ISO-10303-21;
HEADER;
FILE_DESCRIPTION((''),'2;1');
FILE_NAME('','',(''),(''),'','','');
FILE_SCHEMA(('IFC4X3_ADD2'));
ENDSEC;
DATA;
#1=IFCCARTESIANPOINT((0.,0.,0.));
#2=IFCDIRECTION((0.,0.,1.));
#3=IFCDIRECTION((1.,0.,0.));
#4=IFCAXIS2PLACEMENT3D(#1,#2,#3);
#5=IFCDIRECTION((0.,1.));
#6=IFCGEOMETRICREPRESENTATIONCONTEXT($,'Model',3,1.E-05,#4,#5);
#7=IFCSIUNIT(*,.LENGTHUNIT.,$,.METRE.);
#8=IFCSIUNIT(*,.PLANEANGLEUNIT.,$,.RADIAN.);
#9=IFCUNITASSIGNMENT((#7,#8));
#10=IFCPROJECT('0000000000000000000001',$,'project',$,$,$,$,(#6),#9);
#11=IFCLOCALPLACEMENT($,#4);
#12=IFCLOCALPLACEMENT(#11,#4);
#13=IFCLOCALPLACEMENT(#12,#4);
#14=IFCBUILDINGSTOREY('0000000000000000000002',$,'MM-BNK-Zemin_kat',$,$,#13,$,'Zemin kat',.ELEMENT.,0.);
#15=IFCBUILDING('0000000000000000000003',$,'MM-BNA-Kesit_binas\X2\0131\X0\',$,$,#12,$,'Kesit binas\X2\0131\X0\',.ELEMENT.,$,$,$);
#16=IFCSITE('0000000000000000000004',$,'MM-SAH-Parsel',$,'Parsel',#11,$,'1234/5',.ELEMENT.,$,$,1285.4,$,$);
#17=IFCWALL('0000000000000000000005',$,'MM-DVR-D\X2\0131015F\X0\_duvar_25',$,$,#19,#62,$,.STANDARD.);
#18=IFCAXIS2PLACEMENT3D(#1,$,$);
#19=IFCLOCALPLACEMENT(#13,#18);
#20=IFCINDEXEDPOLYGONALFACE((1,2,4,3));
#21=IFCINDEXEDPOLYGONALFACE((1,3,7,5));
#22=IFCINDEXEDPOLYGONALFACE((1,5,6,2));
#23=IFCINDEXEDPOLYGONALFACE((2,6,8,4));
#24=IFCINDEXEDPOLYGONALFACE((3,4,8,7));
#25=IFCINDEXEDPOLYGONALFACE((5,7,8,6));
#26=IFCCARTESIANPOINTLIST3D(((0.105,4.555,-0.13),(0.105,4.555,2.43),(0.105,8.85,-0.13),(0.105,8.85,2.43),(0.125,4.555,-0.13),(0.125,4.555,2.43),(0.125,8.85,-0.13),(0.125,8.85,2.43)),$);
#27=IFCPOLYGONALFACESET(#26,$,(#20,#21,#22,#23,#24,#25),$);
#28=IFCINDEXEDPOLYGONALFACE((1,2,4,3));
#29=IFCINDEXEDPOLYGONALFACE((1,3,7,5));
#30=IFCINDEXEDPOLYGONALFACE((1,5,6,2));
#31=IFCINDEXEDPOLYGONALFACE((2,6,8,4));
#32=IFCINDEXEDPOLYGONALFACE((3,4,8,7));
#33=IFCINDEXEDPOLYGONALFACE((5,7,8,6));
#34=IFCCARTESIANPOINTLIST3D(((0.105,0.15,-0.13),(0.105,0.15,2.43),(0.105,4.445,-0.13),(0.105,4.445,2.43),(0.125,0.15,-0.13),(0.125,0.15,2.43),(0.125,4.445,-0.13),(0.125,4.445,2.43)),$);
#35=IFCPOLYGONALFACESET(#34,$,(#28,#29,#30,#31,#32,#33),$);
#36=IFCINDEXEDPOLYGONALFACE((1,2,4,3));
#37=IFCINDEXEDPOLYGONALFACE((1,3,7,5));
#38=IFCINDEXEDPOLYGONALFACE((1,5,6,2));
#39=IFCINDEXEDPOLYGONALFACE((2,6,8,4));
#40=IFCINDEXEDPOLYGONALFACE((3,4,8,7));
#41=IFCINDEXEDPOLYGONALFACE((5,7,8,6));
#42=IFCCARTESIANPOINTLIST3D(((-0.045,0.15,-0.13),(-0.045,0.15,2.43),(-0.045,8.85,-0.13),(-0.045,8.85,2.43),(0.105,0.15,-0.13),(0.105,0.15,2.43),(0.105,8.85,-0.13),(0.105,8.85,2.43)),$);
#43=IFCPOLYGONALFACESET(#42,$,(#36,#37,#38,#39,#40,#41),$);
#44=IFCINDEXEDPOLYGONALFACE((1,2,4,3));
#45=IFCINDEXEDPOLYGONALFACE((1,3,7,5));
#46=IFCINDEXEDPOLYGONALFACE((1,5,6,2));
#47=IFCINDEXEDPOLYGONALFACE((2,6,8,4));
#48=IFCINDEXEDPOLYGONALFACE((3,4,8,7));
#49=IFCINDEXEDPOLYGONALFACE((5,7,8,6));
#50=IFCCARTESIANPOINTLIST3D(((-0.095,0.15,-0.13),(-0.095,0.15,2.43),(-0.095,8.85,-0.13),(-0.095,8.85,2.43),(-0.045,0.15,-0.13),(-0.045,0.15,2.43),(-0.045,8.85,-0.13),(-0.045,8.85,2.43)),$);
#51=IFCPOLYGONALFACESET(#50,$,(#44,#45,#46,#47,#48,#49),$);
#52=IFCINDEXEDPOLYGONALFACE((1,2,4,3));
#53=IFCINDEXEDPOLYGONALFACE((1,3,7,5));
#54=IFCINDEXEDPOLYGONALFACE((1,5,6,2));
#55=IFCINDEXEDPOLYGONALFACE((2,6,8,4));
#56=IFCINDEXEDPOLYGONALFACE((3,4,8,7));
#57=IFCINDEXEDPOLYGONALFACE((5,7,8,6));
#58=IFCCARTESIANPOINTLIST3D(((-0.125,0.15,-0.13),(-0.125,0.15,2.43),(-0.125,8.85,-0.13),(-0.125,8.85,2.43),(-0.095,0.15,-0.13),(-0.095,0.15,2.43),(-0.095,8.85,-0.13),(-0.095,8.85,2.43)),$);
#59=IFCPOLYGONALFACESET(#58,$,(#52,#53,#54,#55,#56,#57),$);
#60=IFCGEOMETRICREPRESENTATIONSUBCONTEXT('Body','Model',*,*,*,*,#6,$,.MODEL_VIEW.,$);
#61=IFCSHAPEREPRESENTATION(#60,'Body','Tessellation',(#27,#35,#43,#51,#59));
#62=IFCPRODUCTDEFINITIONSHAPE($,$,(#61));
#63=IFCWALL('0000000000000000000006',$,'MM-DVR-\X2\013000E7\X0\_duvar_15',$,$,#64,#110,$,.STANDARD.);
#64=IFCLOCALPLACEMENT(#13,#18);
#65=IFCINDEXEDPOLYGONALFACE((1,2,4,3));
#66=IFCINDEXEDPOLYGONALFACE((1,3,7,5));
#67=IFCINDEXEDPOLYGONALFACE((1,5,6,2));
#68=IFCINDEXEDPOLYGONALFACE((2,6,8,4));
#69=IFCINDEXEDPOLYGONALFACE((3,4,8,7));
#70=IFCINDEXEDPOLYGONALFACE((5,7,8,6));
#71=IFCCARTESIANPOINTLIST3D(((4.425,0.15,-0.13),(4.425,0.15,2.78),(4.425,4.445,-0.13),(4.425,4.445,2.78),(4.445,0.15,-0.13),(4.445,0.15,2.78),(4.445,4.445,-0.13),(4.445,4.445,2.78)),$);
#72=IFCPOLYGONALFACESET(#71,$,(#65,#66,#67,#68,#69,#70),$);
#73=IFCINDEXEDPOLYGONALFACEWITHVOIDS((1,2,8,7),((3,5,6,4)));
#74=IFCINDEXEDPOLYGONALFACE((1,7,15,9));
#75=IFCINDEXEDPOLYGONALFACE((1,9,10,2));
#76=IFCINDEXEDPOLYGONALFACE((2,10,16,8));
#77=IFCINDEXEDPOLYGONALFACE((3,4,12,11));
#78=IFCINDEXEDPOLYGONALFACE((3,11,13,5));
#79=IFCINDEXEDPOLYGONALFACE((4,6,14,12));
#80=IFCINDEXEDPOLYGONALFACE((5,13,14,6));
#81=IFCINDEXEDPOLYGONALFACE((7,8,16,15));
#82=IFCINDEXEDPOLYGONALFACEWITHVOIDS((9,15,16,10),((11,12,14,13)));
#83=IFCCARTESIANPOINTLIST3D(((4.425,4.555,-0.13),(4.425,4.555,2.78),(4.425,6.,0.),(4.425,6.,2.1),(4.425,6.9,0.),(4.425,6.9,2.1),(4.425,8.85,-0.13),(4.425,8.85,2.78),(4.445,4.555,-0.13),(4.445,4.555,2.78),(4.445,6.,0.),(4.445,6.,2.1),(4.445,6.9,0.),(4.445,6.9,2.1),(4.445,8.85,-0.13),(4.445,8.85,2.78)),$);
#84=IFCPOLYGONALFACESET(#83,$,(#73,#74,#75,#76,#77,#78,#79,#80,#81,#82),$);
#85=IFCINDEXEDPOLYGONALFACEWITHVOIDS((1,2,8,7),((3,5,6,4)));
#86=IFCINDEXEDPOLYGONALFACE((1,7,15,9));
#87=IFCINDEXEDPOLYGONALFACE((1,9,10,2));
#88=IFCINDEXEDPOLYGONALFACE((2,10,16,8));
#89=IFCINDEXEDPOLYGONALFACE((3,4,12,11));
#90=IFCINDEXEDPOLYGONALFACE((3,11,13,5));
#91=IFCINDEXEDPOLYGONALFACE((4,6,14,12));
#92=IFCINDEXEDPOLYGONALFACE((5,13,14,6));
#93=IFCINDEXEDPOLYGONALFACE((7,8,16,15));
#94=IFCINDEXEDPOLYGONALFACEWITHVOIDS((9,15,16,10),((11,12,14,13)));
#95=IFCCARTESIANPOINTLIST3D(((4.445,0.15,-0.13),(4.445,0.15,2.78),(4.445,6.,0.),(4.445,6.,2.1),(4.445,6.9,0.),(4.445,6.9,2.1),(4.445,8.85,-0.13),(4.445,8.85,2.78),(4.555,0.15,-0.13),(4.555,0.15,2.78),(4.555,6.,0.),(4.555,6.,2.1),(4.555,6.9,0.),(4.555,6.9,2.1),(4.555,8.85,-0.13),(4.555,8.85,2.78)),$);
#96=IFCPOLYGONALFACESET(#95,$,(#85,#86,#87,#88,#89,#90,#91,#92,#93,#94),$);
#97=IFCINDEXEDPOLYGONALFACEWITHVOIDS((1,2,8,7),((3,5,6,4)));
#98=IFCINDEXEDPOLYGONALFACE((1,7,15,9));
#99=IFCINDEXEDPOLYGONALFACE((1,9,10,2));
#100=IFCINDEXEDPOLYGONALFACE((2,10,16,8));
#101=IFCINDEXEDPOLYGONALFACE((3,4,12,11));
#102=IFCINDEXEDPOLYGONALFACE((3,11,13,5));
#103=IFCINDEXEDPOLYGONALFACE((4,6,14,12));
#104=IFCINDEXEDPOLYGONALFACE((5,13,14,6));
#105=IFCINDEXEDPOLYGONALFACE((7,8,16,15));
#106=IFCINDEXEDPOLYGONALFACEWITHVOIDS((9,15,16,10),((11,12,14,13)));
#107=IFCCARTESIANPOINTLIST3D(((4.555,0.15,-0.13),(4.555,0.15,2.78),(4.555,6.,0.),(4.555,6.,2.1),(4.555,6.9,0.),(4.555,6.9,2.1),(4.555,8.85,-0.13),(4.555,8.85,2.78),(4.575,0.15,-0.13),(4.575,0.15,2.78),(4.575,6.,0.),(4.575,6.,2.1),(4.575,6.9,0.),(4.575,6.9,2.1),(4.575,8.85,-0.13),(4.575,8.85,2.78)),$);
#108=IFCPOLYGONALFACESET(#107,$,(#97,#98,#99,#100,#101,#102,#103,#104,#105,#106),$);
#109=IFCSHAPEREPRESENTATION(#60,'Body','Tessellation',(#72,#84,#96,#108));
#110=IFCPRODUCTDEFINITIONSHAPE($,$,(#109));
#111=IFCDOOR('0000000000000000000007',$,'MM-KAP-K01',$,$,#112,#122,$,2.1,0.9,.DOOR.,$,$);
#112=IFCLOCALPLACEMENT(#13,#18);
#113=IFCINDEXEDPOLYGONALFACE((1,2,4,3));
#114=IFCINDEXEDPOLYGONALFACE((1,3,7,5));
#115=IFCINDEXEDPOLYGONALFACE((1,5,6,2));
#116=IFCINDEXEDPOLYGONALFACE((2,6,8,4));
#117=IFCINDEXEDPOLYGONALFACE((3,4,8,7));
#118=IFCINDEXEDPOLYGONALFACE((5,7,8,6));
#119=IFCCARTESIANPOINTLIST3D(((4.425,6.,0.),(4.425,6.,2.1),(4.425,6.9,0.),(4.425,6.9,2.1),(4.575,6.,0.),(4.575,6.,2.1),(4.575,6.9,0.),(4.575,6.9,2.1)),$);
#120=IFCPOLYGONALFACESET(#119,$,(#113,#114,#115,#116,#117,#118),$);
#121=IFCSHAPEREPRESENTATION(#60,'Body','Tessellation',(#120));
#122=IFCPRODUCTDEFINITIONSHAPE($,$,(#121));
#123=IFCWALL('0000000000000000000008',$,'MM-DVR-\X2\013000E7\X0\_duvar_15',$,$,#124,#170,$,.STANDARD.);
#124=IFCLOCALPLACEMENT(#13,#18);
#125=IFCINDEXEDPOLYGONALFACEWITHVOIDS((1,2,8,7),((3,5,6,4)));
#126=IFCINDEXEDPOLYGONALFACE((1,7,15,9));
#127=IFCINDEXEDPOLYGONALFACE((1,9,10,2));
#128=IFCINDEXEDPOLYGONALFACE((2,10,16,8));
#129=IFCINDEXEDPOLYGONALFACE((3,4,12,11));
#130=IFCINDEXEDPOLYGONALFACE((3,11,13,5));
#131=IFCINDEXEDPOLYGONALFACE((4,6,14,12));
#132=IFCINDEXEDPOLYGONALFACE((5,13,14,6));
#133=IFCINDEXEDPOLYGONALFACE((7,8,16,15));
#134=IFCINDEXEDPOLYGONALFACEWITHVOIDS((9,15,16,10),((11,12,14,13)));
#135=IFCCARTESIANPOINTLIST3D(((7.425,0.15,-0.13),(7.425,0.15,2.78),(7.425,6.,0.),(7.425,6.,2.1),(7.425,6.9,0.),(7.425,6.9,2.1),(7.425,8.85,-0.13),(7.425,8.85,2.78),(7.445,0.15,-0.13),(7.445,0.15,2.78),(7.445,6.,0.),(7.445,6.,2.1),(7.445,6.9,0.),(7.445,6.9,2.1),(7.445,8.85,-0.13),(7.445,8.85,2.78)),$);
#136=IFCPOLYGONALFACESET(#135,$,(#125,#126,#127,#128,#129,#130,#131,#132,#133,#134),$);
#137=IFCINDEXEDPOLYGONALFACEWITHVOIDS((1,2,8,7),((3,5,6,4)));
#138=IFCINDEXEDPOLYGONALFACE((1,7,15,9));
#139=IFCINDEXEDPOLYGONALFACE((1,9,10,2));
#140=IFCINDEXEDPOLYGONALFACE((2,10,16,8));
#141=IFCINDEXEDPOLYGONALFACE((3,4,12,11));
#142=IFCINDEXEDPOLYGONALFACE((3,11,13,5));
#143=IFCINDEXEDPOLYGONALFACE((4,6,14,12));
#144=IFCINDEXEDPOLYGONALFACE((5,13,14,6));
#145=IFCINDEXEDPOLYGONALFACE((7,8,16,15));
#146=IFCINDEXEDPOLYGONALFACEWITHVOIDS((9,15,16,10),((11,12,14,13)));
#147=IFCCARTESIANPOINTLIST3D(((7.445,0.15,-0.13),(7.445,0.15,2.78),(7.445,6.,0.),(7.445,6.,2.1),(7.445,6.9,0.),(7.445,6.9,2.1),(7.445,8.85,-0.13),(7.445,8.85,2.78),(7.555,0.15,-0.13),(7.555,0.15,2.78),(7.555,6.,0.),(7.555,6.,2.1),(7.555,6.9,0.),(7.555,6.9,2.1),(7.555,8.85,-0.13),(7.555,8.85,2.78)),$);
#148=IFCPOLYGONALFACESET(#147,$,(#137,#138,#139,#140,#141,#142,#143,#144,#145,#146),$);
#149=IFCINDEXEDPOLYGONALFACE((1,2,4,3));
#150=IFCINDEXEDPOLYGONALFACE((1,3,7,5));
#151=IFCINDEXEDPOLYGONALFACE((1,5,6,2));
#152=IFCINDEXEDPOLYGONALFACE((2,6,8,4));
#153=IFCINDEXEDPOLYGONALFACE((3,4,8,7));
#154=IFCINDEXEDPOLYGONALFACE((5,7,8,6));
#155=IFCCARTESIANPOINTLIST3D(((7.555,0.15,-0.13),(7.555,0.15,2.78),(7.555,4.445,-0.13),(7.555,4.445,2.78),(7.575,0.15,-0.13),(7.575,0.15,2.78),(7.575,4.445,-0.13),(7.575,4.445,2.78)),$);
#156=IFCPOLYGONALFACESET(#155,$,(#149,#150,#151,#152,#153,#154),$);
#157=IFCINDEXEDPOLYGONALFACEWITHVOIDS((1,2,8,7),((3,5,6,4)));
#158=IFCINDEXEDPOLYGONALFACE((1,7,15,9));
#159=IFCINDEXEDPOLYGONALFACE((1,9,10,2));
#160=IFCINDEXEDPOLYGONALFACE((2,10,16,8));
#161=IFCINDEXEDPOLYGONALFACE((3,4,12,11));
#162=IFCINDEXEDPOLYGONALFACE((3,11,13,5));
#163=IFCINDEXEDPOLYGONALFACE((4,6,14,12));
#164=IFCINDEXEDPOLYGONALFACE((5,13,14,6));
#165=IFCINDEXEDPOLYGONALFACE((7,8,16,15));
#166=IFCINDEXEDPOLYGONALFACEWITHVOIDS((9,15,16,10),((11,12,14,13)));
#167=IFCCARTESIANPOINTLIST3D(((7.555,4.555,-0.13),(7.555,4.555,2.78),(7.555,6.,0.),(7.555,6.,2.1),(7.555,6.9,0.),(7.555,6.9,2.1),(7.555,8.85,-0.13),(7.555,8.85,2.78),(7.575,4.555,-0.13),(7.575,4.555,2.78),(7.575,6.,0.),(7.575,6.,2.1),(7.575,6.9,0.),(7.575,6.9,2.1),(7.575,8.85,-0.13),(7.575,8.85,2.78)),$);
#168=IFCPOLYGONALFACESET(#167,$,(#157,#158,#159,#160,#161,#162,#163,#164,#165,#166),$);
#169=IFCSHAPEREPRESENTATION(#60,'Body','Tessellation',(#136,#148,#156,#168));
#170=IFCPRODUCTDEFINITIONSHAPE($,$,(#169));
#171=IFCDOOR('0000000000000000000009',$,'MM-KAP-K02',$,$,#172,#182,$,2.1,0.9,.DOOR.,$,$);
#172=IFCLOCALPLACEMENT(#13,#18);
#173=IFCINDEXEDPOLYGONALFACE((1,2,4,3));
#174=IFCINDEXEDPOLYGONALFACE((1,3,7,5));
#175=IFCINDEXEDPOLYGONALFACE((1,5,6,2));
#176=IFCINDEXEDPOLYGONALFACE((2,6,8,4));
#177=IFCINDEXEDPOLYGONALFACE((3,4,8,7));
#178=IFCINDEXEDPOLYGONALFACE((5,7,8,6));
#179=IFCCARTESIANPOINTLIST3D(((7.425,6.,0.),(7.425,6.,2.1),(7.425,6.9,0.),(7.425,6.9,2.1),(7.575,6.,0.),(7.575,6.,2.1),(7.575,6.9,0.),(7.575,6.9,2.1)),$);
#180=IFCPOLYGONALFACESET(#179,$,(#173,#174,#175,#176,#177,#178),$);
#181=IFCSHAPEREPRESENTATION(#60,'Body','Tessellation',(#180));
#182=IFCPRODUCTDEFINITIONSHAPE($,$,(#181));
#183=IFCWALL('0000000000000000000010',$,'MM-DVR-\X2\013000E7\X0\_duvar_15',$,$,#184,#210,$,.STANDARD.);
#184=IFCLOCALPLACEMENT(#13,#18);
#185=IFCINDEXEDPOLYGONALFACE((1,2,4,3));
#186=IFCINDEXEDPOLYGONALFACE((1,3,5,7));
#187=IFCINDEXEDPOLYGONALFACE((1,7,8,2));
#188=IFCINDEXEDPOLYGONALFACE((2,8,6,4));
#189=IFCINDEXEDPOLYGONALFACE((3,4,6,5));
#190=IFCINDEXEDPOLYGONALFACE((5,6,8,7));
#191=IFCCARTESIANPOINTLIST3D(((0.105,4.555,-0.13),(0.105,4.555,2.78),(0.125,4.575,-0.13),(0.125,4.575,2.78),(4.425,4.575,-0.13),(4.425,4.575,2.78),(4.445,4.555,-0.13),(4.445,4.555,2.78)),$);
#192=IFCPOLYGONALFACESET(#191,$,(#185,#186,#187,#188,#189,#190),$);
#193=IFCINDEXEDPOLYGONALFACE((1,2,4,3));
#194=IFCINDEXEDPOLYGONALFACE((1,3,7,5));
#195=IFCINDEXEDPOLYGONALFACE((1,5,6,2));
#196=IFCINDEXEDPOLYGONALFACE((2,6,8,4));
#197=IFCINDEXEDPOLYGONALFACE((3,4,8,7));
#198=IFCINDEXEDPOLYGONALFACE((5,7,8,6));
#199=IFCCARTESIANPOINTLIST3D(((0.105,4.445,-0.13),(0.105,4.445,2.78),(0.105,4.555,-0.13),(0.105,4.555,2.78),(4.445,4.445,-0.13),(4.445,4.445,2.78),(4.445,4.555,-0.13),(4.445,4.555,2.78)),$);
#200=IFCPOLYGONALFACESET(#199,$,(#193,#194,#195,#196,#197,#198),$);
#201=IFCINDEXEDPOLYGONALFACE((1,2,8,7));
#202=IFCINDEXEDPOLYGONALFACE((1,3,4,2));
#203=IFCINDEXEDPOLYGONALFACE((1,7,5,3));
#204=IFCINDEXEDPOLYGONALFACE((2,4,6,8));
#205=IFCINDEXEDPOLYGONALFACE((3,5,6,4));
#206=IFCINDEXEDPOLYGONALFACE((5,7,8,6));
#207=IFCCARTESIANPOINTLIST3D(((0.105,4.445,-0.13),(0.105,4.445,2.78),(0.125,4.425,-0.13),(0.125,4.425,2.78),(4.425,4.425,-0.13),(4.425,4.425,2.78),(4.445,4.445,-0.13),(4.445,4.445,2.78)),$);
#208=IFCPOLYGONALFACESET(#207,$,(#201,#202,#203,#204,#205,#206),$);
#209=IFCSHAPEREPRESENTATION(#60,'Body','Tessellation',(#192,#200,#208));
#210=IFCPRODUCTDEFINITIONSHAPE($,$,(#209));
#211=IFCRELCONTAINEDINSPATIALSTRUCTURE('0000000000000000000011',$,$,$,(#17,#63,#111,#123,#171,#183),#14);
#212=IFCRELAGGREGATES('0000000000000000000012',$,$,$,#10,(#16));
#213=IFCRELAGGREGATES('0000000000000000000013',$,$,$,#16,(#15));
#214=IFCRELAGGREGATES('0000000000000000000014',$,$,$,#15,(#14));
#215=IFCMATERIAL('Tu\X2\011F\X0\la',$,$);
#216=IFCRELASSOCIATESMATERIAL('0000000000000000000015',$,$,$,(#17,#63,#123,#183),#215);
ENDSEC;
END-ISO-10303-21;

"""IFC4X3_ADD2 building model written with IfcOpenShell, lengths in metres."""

from ifc_helpers import new_model, si_unit, direction, frame, origin, origin_with_axes, place, context, subcontext, project, spatial, polyline, outline, extrude, material, element, fill, save


model = new_model("IFC4X3_ADD2")

# Units and contexts
model_context = context("Model", 3, precision=1e-05, world=origin_with_axes(), true_north=direction((0.0, 1.0)))
body_context = subcontext(model_context, "Body", "Model", "MODEL_VIEW")
ifc_project = project(units=[si_unit("LENGTHUNIT", "METRE"), si_unit("PLANEANGLEUNIT", "RADIAN")], contexts=[model_context])

# Site, building, storey
site_placement = place(None, origin_with_axes())
site = spatial("IfcSite", under=ifc_project, at=site_placement, Name="MM-SAH-Parsel", ObjectType="Parsel", LongName="1234/5", CompositionType="ELEMENT", RefElevation=1285.4)
building_placement = place(site_placement, origin_with_axes())
building = spatial("IfcBuilding", under=site, at=building_placement, Name="MM-BNA-Kesit_binası", LongName="Kesit binası", CompositionType="ELEMENT")
storey_placement = place(building_placement, origin_with_axes())
storey = spatial("IfcBuildingStorey", under=building, at=storey_placement, Name="MM-BNK-Zemin_kat", LongName="Zemin kat", CompositionType="ELEMENT", Elevation=0.0)

# Shared definitions
ifc_material_1 = material(Name="Tuğla")

# Wall
wall_1_placement = place(storey_placement, origin_with_axes())
element("IfcWall", 1, at=wall_1_placement, inside=storey, material=ifc_material_1, Name="MM-DVR-Dış_duvar_25", PredefinedType="STANDARD", context=body_context, shape_type="SweptSolid", body=[
    extrude(outline(polyline([(0.105, 8.85), (0.105, 4.555), (0.125, 4.555), (0.125, 8.85), (0.105, 8.85)])), frame((0.0, 0.0, -0.13)), (0.0, 0.0, 1.0), 2.56),
    extrude(outline(polyline([(0.105, 4.445), (0.105, 0.15), (0.125, 0.15), (0.125, 4.445), (0.105, 4.445)])), frame((0.0, 0.0, -0.13)), (0.0, 0.0, 1.0), 2.56),
    extrude(outline(polyline([(-0.045, 8.85), (-0.045, 0.15), (0.105, 0.15), (0.105, 8.85), (-0.045, 8.85)])), frame((0.0, 0.0, -0.13)), (0.0, 0.0, 1.0), 2.56),
    extrude(outline(polyline([(-0.095, 8.85), (-0.095, 0.15), (-0.045, 0.15), (-0.045, 8.85), (-0.095, 8.85)])), frame((0.0, 0.0, -0.13)), (0.0, 0.0, 1.0), 2.56),
    extrude(outline(polyline([(-0.125, 8.85), (-0.125, 0.15), (-0.095, 0.15), (-0.095, 8.85), (-0.125, 8.85)])), frame((0.0, 0.0, -0.13)), (0.0, 0.0, 1.0), 2.56),
])

# Walls, openings, doors
wall_2_placement = place(storey_placement, origin_with_axes())
wall_2 = element("IfcWall", 2, at=wall_2_placement, inside=storey, material=ifc_material_1, Name="MM-DVR-İç_duvar_15", PredefinedType="STANDARD", context=body_context, shape_type="SweptSolid", body=[
    extrude(outline(polyline([(4.445, 0.15), (4.445, 4.445), (4.425, 4.445), (4.425, 0.15), (4.445, 0.15)])), frame((0.0, 0.0, -0.13)), (0.0, 0.0, 1.0), 2.91),
    extrude(outline(polyline([(4.445, 4.555), (4.445, 8.85), (4.425, 8.85), (4.425, 4.555), (4.445, 4.555)])), frame((0.0, 0.0, -0.13)), (0.0, 0.0, 1.0), 2.91),
    extrude(outline(polyline([(4.555, 0.15), (4.555, 8.85), (4.445, 8.85), (4.445, 0.15), (4.555, 0.15)])), frame((0.0, 0.0, -0.13)), (0.0, 0.0, 1.0), 2.91),
    extrude(outline(polyline([(4.575, 0.15), (4.575, 8.85), (4.555, 8.85), (4.555, 0.15), (4.575, 0.15)])), frame((0.0, 0.0, -0.13)), (0.0, 0.0, 1.0), 2.91),
])
opening_1_placement = place(storey_placement, origin_with_axes())
opening_1 = element("IfcOpeningElement", 3, at=opening_1_placement, cuts=wall_2, PredefinedType="OPENING", context=body_context, shape_type="SweptSolid", body=[
    extrude(outline(polyline([(4.425, 6.0), (4.425, 6.9), (4.575, 6.9), (4.575, 6.0), (4.425, 6.0)])), origin(), (0.0, 0.0, 1.0), 2.1),
])
door_1_placement = place(storey_placement, origin_with_axes())
door_1 = element("IfcDoor", 4, at=door_1_placement, inside=storey, Name="MM-KAP-K01", OverallHeight=2.1, OverallWidth=0.9, PredefinedType="DOOR", context=body_context, shape_type="SweptSolid", body=[
    extrude(outline(polyline([(4.425, 6.0), (4.425, 6.9), (4.575, 6.9), (4.575, 6.0), (4.425, 6.0)])), origin(), (0.0, 0.0, 1.0), 2.1),
])
fill(opening_1, door_1)
wall_3_placement = place(storey_placement, origin_with_axes())
wall_3 = element("IfcWall", 5, at=wall_3_placement, inside=storey, material=ifc_material_1, Name="MM-DVR-İç_duvar_15", PredefinedType="STANDARD", context=body_context, shape_type="SweptSolid", body=[
    extrude(outline(polyline([(7.445, 0.15), (7.445, 8.85), (7.425, 8.85), (7.425, 0.15), (7.445, 0.15)])), frame((0.0, 0.0, -0.13)), (0.0, 0.0, 1.0), 2.91),
    extrude(outline(polyline([(7.555, 0.15), (7.555, 8.85), (7.445, 8.85), (7.445, 0.15), (7.555, 0.15)])), frame((0.0, 0.0, -0.13)), (0.0, 0.0, 1.0), 2.91),
    extrude(outline(polyline([(7.575, 0.15), (7.575, 4.445), (7.555, 4.445), (7.555, 0.15), (7.575, 0.15)])), frame((0.0, 0.0, -0.13)), (0.0, 0.0, 1.0), 2.91),
    extrude(outline(polyline([(7.575, 4.555), (7.575, 8.85), (7.555, 8.85), (7.555, 4.555), (7.575, 4.555)])), frame((0.0, 0.0, -0.13)), (0.0, 0.0, 1.0), 2.91),
])
opening_2_placement = place(storey_placement, origin_with_axes())
opening_2 = element("IfcOpeningElement", 6, at=opening_2_placement, cuts=wall_3, PredefinedType="OPENING", context=body_context, shape_type="SweptSolid", body=[
    extrude(outline(polyline([(7.425, 6.0), (7.425, 6.9), (7.575, 6.9), (7.575, 6.0), (7.425, 6.0)])), origin(), (0.0, 0.0, 1.0), 2.1),
])
door_2_placement = place(storey_placement, origin_with_axes())
door_2 = element("IfcDoor", 7, at=door_2_placement, inside=storey, Name="MM-KAP-K02", OverallHeight=2.1, OverallWidth=0.9, PredefinedType="DOOR", context=body_context, shape_type="SweptSolid", body=[
    extrude(outline(polyline([(7.425, 6.0), (7.425, 6.9), (7.575, 6.9), (7.575, 6.0), (7.425, 6.0)])), origin(), (0.0, 0.0, 1.0), 2.1),
])
fill(opening_2, door_2)

# Wall
wall_4_placement = place(storey_placement, origin_with_axes())
element("IfcWall", 8, at=wall_4_placement, inside=storey, material=ifc_material_1, Name="MM-DVR-İç_duvar_15", PredefinedType="STANDARD", context=body_context, shape_type="SweptSolid", body=[
    extrude(outline(polyline([(0.125, 4.575), (4.425, 4.575), (4.445, 4.555), (0.105, 4.555), (0.125, 4.575)])), frame((0.0, 0.0, -0.13)), (0.0, 0.0, 1.0), 2.91),
    extrude(outline(polyline([(0.105, 4.555), (4.445, 4.555), (4.445, 4.445), (0.105, 4.445), (0.105, 4.555)])), frame((0.0, 0.0, -0.13)), (0.0, 0.0, 1.0), 2.91),
    extrude(outline(polyline([(0.105, 4.445), (4.445, 4.445), (4.425, 4.425), (0.125, 4.425), (0.105, 4.445)])), frame((0.0, 0.0, -0.13)), (0.0, 0.0, 1.0), 2.91),
])

save(model, "model.ifc")
